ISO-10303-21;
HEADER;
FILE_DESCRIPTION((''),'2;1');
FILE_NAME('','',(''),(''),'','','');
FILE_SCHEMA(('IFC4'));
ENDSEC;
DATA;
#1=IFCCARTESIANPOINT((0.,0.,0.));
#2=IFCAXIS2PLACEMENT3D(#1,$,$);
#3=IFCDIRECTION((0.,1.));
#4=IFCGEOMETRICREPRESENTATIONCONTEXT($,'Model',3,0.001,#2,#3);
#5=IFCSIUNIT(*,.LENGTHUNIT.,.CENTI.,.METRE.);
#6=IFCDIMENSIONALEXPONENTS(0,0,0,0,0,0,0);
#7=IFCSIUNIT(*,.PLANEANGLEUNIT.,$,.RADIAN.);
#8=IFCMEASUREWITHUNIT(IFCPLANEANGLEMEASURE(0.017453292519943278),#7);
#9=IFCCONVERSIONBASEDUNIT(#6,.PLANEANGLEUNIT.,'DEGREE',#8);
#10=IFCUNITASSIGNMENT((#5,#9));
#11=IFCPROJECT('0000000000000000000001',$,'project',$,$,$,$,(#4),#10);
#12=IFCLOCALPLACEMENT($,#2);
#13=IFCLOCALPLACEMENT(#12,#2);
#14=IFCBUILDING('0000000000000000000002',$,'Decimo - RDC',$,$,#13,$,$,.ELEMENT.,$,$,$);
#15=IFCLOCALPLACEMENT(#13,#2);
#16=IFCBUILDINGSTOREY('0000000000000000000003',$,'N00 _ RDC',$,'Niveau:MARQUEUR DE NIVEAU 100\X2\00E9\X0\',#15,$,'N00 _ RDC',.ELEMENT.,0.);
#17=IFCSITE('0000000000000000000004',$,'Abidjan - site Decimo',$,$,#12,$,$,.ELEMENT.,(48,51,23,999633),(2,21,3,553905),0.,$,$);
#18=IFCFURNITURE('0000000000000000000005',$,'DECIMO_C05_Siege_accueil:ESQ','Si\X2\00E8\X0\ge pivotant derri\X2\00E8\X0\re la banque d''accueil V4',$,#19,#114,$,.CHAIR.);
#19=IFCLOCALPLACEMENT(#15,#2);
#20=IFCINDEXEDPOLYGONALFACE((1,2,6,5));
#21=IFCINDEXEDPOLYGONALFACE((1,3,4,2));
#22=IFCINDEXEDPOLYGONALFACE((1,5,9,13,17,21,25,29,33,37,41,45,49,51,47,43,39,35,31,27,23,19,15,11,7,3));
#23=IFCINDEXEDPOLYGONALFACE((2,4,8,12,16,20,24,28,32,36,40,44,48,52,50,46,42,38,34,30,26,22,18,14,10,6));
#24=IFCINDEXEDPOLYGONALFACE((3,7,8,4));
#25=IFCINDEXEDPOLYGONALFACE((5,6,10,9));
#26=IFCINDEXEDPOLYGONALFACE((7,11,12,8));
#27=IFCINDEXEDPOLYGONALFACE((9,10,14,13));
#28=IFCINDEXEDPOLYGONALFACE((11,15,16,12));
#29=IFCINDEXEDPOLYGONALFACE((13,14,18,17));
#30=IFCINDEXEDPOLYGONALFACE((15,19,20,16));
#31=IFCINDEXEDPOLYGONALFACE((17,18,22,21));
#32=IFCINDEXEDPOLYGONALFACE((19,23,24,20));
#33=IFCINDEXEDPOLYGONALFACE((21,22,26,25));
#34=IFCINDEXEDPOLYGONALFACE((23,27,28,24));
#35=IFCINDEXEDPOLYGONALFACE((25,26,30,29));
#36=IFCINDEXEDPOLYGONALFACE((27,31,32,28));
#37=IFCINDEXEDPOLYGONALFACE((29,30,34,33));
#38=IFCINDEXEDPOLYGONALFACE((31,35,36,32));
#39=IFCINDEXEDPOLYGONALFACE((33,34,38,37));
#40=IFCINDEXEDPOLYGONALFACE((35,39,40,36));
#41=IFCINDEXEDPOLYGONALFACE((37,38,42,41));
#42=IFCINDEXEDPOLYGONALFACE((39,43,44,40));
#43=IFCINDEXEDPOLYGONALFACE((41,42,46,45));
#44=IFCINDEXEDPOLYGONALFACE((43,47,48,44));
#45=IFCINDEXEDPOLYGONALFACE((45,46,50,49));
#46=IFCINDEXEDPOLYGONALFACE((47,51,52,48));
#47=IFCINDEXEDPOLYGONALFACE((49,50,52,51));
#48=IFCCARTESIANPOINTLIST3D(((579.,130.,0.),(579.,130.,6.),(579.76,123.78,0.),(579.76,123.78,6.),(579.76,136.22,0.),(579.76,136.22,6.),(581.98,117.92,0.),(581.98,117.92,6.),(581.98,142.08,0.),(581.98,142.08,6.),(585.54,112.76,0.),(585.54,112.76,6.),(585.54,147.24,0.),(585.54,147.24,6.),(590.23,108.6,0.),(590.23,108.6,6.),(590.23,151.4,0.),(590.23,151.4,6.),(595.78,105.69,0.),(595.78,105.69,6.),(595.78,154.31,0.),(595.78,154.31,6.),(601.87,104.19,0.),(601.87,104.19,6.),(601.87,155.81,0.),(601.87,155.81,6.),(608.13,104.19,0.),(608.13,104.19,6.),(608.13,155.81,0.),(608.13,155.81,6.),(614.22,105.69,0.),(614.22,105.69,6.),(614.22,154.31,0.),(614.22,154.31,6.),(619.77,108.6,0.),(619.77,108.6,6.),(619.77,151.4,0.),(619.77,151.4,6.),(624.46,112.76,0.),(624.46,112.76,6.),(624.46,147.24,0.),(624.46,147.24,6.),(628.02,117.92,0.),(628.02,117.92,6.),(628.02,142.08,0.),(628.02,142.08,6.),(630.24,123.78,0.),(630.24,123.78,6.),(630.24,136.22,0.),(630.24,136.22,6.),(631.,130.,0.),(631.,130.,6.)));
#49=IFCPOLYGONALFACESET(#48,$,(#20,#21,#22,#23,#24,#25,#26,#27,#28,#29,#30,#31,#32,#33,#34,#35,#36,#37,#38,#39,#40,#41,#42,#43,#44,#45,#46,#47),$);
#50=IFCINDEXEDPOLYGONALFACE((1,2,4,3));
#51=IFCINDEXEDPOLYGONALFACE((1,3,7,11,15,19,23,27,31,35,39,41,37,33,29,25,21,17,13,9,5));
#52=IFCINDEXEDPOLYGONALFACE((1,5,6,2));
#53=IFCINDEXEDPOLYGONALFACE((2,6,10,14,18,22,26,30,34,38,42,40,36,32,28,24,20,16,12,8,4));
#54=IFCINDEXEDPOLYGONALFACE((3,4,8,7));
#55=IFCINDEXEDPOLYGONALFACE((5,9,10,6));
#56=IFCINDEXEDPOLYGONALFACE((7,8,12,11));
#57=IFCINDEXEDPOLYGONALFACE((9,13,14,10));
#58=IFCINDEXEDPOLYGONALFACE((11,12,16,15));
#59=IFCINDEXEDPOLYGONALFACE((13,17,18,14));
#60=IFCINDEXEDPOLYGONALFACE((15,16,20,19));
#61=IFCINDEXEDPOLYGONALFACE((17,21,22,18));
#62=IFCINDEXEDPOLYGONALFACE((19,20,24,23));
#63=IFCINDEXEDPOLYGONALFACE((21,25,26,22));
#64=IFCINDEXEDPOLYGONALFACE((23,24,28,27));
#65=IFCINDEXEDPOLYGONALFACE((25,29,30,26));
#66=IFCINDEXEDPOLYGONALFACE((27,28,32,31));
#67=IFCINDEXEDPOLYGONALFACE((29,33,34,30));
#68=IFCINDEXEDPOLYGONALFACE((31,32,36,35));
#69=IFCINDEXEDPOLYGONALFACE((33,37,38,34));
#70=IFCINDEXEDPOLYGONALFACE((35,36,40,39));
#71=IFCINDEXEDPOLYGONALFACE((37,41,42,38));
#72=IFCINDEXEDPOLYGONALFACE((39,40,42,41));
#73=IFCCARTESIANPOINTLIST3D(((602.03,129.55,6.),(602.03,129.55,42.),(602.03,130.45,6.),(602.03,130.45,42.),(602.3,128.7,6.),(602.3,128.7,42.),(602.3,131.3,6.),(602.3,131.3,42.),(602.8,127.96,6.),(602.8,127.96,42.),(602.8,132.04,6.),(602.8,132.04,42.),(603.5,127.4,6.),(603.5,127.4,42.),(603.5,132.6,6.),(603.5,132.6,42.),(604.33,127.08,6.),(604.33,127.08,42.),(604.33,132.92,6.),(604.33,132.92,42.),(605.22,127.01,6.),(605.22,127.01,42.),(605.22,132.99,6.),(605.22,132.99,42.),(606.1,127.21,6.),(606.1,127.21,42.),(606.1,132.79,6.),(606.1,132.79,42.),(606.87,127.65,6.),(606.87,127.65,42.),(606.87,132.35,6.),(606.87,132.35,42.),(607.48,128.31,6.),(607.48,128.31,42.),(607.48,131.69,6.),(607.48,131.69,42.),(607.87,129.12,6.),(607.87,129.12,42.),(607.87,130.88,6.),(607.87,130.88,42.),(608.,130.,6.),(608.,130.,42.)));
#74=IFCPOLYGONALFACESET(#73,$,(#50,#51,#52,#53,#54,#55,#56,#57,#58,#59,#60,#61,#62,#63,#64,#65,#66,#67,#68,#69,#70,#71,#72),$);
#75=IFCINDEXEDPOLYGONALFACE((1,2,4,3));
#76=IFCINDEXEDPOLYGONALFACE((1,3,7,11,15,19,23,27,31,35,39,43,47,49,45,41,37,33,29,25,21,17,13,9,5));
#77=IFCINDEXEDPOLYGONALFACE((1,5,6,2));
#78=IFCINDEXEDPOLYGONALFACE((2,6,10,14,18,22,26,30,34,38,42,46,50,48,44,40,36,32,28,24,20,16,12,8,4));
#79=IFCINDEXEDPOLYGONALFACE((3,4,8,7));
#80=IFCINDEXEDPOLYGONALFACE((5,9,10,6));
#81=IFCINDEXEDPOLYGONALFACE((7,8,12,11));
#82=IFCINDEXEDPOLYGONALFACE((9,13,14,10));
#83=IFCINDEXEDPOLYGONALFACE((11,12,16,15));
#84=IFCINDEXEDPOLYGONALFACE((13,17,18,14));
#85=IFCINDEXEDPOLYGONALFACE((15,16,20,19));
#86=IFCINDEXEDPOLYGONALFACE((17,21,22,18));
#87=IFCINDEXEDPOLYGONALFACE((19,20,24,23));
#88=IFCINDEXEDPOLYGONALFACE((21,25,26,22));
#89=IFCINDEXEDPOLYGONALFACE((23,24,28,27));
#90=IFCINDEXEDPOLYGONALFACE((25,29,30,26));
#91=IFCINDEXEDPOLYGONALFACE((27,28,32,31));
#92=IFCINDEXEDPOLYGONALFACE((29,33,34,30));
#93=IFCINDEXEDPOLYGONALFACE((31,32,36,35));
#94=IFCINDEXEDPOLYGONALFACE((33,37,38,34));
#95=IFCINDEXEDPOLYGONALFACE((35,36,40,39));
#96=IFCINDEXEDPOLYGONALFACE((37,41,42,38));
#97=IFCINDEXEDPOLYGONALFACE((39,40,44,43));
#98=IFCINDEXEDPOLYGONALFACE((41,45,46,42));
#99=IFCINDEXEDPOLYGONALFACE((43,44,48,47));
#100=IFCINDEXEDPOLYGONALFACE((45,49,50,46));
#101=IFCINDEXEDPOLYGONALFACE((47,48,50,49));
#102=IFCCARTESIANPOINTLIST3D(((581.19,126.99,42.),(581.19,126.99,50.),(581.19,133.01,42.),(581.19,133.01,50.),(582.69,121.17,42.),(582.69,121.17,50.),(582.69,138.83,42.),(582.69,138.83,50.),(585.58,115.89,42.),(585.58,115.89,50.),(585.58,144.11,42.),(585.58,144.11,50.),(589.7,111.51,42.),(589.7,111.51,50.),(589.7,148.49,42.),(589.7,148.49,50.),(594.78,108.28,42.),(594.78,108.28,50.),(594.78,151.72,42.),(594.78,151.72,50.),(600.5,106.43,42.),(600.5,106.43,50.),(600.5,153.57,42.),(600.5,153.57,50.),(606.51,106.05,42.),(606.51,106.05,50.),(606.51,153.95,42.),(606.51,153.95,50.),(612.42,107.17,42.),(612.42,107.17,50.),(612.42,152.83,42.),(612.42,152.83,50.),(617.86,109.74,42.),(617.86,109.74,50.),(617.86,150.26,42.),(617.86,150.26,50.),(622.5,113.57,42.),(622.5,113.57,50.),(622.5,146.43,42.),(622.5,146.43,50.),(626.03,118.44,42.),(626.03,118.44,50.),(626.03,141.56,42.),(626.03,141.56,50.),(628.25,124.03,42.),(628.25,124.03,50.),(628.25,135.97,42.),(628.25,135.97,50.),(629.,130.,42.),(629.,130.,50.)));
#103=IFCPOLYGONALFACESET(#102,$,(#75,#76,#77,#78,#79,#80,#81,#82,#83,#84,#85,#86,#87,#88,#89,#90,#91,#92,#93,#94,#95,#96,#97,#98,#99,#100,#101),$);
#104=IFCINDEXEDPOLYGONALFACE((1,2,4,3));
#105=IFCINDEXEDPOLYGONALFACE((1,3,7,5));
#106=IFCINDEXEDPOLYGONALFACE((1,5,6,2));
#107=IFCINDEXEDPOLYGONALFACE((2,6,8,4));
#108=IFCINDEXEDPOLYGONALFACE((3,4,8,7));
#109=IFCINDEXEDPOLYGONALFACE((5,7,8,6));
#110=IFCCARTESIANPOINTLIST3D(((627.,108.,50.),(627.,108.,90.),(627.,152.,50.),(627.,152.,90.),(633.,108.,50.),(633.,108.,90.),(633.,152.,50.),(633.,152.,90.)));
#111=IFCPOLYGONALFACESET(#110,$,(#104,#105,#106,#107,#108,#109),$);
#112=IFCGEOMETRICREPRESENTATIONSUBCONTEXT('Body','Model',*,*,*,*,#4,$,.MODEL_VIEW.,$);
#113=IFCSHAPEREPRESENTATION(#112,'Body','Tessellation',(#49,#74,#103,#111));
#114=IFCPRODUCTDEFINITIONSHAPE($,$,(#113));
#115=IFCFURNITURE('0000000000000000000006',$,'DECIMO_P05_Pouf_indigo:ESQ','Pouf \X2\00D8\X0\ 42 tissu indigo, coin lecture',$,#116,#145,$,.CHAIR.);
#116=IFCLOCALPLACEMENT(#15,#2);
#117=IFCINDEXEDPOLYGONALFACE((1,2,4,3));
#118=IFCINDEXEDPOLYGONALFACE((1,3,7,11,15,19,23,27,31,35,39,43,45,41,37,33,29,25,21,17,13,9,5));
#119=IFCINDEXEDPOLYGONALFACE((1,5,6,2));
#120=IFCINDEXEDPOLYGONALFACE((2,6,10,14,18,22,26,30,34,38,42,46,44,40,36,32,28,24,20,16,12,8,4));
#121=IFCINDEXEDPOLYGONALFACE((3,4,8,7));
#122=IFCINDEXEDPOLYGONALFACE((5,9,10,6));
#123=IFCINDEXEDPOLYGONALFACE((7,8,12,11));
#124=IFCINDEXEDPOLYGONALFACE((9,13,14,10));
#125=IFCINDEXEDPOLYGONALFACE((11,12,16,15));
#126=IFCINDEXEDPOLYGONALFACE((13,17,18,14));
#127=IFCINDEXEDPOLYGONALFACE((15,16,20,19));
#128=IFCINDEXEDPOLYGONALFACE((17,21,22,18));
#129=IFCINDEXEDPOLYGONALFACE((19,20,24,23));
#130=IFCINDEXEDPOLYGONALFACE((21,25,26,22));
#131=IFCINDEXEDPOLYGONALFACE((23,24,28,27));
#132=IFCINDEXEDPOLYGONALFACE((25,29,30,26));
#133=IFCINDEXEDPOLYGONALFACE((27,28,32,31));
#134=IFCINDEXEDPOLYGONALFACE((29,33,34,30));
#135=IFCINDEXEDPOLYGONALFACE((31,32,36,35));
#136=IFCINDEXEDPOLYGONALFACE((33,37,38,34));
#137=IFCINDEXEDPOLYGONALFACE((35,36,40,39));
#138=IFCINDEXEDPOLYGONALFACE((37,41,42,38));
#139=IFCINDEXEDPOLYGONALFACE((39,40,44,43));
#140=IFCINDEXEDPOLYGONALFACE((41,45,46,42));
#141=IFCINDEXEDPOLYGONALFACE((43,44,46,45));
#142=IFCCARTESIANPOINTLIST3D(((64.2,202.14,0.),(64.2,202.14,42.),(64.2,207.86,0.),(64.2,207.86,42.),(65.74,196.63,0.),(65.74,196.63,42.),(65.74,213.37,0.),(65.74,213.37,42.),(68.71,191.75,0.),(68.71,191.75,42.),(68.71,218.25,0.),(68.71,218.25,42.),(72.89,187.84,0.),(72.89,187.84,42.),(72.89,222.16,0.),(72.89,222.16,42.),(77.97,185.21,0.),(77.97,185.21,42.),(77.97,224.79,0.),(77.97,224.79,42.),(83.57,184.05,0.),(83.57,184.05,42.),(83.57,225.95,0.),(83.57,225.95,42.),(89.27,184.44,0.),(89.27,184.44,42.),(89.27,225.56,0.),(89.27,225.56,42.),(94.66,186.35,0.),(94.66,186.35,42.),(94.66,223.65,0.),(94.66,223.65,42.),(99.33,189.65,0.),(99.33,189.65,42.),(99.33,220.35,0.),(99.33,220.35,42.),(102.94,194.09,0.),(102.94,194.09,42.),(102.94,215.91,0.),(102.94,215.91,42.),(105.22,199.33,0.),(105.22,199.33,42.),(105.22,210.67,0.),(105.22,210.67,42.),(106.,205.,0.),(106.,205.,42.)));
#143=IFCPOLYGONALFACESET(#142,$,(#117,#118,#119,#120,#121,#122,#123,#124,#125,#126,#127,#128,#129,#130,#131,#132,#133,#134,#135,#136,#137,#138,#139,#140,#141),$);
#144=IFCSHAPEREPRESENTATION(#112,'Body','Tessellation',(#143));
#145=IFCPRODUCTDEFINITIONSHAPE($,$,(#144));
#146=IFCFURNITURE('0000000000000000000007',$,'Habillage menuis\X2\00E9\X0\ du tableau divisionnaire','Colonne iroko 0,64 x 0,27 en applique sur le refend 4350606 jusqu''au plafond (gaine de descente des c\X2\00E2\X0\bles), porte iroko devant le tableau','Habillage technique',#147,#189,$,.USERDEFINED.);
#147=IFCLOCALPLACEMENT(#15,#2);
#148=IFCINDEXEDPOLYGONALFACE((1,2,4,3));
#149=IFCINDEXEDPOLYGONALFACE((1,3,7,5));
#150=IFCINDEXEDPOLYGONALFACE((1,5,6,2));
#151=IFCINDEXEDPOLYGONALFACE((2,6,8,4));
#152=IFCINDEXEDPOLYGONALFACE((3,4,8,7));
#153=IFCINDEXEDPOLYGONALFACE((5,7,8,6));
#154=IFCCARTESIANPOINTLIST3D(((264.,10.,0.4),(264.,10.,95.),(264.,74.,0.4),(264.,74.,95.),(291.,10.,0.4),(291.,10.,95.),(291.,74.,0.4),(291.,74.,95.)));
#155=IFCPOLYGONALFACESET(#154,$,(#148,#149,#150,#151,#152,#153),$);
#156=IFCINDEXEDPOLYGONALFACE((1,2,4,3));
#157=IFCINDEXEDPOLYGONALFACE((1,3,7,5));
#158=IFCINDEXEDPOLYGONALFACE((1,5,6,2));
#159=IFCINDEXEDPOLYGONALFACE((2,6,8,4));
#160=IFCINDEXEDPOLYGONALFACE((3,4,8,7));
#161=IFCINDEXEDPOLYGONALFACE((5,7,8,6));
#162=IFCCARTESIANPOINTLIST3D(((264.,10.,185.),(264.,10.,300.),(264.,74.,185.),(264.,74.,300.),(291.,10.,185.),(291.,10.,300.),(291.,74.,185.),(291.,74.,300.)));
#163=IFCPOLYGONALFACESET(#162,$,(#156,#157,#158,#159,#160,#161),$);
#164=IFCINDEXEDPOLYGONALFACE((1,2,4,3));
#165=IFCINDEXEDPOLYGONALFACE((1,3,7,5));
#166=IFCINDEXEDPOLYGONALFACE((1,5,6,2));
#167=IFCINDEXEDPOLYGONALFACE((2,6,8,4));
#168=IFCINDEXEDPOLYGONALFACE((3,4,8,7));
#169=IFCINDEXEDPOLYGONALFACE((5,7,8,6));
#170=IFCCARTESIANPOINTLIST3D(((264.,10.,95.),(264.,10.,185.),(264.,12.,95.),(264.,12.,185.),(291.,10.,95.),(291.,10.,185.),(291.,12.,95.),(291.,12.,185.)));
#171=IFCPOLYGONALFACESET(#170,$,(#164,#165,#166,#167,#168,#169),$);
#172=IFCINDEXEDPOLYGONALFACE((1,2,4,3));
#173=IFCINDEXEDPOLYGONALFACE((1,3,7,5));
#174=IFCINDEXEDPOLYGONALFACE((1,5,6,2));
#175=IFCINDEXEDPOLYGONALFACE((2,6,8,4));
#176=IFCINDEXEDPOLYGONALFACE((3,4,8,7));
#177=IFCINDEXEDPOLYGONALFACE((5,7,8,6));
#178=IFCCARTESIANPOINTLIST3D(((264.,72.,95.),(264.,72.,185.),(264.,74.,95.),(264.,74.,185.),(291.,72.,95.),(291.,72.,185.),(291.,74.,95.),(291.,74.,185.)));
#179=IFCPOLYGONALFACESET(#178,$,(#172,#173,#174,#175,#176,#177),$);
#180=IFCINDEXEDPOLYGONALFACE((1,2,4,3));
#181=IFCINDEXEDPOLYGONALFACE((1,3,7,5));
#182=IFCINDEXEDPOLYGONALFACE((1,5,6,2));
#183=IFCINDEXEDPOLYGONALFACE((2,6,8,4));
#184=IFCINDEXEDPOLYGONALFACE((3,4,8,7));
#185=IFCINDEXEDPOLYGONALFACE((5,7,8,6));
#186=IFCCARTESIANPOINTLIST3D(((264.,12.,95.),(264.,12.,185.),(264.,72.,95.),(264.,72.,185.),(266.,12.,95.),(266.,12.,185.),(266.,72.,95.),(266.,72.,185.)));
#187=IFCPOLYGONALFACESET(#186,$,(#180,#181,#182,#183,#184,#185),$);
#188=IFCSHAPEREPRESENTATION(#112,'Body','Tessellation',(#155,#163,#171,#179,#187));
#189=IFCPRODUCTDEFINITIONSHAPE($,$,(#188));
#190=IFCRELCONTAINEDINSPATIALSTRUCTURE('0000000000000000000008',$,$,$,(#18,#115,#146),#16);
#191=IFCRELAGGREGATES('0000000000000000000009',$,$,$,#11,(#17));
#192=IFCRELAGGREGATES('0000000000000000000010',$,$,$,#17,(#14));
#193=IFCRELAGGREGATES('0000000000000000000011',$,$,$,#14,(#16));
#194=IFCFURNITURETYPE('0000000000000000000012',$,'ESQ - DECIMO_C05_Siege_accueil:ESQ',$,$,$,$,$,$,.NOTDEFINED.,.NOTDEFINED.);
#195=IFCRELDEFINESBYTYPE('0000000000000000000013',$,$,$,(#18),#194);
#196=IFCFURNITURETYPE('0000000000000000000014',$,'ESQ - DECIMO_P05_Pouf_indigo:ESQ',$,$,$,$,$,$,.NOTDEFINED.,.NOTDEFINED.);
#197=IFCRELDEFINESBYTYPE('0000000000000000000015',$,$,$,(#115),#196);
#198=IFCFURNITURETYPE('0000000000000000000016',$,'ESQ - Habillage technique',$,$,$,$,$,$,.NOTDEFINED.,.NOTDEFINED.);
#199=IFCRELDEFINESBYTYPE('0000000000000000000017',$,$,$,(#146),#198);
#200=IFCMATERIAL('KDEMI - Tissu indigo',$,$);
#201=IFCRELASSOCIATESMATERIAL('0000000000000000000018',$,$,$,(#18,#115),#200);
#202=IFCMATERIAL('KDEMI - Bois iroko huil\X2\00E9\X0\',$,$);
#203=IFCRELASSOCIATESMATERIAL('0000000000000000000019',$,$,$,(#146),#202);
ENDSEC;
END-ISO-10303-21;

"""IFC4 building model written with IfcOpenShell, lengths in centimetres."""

from ifc_helpers import new_model, entity, si_unit, converted_unit, direction, frame, frame_2d, origin, origin_with_axes, place, context, subcontext, project, spatial, rectangle, circle, extrude, material, type_object, element, save


model = new_model("IFC4")

# Units and contexts
model_context = context("Model", 3, precision=0.001, world=origin(), true_north=direction((0.0, 1.0)))
body_context = subcontext(model_context, "Body", "Model", "MODEL_VIEW")
ifc_project = project(units=[si_unit("LENGTHUNIT", "METRE", prefix="CENTI"), converted_unit("PLANEANGLEUNIT", "DEGREE", entity("IfcPlaneAngleMeasure", 0.017453292519943278), si_unit("PLANEANGLEUNIT", "RADIAN"), dimensions=[0, 0, 0, 0, 0, 0, 0])], contexts=[model_context])

# Site, building, storey
site_placement = place(None, origin())
site = spatial("IfcSite", under=ifc_project, at=site_placement, Name="Abidjan - site Decimo", CompositionType="ELEMENT", RefLatitude=(48, 51, 23, 999633), RefLongitude=(2, 21, 3, 553905), RefElevation=0.0)
building_placement = place(site_placement, origin())
building = spatial("IfcBuilding", under=site, at=building_placement, Name="Decimo - RDC", CompositionType="ELEMENT")
storey_placement = place(building_placement, origin())
storey = spatial("IfcBuildingStorey", under=building, at=storey_placement, Name="N00 _ RDC", ObjectType="Niveau:MARQUEUR DE NIVEAU 100é", LongName="N00 _ RDC", CompositionType="ELEMENT", Elevation=0.0)

# Shared definitions
ifc_material_1 = material(Name="KDEMI - Bois iroko huilé")

# Furniture
ifc_material_2 = material(Name="KDEMI - Tissu indigo")
furniture_type_1 = type_object("IfcFurnitureType", Name="ESQ - DECIMO_C05_Siege_accueil:ESQ", AssemblyPlace="NOTDEFINED", PredefinedType="NOTDEFINED")
furniture_1_placement = place(storey_placement, origin_with_axes())
element("IfcFurniture", 1, at=furniture_1_placement, inside=storey, type_object=furniture_type_1, material=ifc_material_2, Name="DECIMO_C05_Siege_accueil:ESQ", Description="Siège pivotant derrière la banque d'accueil V4", PredefinedType="CHAIR", context=body_context, shape_type="SweptSolid", body=[
    extrude(circle(Radius=26.0, at=frame_2d((605.0, 130.0))), origin(), (0.0, 0.0, 1.0), 6.0),
    extrude(circle(Radius=3.0, at=frame_2d((605.0, 130.0))), frame((0.0, 0.0, 6.0)), (0.0, 0.0, 1.0), 36.0),
    extrude(circle(Radius=24.0, at=frame_2d((605.0, 130.0))), frame((0.0, 0.0, 42.0)), (0.0, 0.0, 1.0), 8.0),
    extrude(rectangle(XDim=6.0, YDim=44.0, at=frame_2d((630.0, 130.0))), frame((0.0, 0.0, 50.0)), (0.0, 0.0, 1.0), 40.0),
])
furniture_type_2 = type_object("IfcFurnitureType", Name="ESQ - DECIMO_P05_Pouf_indigo:ESQ", AssemblyPlace="NOTDEFINED", PredefinedType="NOTDEFINED")
furniture_2_placement = place(storey_placement, origin_with_axes())
element("IfcFurniture", 2, at=furniture_2_placement, inside=storey, type_object=furniture_type_2, material=ifc_material_2, Name="DECIMO_P05_Pouf_indigo:ESQ", Description="Pouf Ø 42 tissu indigo, coin lecture", PredefinedType="CHAIR", context=body_context, shape_type="SweptSolid", body=[
    extrude(circle(Radius=21.0, at=frame_2d((85.0, 205.0))), origin(), (0.0, 0.0, 1.0), 42.0),
])
furniture_type_3 = type_object("IfcFurnitureType", Name="ESQ - Habillage technique", AssemblyPlace="NOTDEFINED", PredefinedType="NOTDEFINED")
furniture_3_placement = place(storey_placement, origin_with_axes())
element("IfcFurniture", 3, at=furniture_3_placement, inside=storey, type_object=furniture_type_3, material=ifc_material_1, Name="Habillage menuisé du tableau divisionnaire", Description="Colonne iroko 0,64 x 0,27 en applique sur le refend 4350606 jusqu'au plafond (gaine de descente des câbles), porte iroko devant le tableau", ObjectType="Habillage technique", PredefinedType="USERDEFINED", context=body_context, shape_type="SweptSolid", body=[
    extrude(rectangle(XDim=27.0, YDim=64.0, at=frame_2d((277.5, 42.0))), frame((0.0, 0.0, 0.4)), (0.0, 0.0, 1.0), 94.6),
    extrude(rectangle(XDim=27.0, YDim=64.0, at=frame_2d((277.5, 42.0))), frame((0.0, 0.0, 185.0)), (0.0, 0.0, 1.0), 115.0),
    extrude(rectangle(XDim=27.0, YDim=2.0, at=frame_2d((277.5, 11.0))), frame((0.0, 0.0, 95.0)), (0.0, 0.0, 1.0), 90.0),
    extrude(rectangle(XDim=27.0, YDim=2.0, at=frame_2d((277.5, 73.0))), frame((0.0, 0.0, 95.0)), (0.0, 0.0, 1.0), 90.0),
    extrude(rectangle(XDim=2.0, YDim=60.0, at=frame_2d((265.0, 42.0))), frame((0.0, 0.0, 95.0)), (0.0, 0.0, 1.0), 90.0),
])

save(model, "model.ifc")
